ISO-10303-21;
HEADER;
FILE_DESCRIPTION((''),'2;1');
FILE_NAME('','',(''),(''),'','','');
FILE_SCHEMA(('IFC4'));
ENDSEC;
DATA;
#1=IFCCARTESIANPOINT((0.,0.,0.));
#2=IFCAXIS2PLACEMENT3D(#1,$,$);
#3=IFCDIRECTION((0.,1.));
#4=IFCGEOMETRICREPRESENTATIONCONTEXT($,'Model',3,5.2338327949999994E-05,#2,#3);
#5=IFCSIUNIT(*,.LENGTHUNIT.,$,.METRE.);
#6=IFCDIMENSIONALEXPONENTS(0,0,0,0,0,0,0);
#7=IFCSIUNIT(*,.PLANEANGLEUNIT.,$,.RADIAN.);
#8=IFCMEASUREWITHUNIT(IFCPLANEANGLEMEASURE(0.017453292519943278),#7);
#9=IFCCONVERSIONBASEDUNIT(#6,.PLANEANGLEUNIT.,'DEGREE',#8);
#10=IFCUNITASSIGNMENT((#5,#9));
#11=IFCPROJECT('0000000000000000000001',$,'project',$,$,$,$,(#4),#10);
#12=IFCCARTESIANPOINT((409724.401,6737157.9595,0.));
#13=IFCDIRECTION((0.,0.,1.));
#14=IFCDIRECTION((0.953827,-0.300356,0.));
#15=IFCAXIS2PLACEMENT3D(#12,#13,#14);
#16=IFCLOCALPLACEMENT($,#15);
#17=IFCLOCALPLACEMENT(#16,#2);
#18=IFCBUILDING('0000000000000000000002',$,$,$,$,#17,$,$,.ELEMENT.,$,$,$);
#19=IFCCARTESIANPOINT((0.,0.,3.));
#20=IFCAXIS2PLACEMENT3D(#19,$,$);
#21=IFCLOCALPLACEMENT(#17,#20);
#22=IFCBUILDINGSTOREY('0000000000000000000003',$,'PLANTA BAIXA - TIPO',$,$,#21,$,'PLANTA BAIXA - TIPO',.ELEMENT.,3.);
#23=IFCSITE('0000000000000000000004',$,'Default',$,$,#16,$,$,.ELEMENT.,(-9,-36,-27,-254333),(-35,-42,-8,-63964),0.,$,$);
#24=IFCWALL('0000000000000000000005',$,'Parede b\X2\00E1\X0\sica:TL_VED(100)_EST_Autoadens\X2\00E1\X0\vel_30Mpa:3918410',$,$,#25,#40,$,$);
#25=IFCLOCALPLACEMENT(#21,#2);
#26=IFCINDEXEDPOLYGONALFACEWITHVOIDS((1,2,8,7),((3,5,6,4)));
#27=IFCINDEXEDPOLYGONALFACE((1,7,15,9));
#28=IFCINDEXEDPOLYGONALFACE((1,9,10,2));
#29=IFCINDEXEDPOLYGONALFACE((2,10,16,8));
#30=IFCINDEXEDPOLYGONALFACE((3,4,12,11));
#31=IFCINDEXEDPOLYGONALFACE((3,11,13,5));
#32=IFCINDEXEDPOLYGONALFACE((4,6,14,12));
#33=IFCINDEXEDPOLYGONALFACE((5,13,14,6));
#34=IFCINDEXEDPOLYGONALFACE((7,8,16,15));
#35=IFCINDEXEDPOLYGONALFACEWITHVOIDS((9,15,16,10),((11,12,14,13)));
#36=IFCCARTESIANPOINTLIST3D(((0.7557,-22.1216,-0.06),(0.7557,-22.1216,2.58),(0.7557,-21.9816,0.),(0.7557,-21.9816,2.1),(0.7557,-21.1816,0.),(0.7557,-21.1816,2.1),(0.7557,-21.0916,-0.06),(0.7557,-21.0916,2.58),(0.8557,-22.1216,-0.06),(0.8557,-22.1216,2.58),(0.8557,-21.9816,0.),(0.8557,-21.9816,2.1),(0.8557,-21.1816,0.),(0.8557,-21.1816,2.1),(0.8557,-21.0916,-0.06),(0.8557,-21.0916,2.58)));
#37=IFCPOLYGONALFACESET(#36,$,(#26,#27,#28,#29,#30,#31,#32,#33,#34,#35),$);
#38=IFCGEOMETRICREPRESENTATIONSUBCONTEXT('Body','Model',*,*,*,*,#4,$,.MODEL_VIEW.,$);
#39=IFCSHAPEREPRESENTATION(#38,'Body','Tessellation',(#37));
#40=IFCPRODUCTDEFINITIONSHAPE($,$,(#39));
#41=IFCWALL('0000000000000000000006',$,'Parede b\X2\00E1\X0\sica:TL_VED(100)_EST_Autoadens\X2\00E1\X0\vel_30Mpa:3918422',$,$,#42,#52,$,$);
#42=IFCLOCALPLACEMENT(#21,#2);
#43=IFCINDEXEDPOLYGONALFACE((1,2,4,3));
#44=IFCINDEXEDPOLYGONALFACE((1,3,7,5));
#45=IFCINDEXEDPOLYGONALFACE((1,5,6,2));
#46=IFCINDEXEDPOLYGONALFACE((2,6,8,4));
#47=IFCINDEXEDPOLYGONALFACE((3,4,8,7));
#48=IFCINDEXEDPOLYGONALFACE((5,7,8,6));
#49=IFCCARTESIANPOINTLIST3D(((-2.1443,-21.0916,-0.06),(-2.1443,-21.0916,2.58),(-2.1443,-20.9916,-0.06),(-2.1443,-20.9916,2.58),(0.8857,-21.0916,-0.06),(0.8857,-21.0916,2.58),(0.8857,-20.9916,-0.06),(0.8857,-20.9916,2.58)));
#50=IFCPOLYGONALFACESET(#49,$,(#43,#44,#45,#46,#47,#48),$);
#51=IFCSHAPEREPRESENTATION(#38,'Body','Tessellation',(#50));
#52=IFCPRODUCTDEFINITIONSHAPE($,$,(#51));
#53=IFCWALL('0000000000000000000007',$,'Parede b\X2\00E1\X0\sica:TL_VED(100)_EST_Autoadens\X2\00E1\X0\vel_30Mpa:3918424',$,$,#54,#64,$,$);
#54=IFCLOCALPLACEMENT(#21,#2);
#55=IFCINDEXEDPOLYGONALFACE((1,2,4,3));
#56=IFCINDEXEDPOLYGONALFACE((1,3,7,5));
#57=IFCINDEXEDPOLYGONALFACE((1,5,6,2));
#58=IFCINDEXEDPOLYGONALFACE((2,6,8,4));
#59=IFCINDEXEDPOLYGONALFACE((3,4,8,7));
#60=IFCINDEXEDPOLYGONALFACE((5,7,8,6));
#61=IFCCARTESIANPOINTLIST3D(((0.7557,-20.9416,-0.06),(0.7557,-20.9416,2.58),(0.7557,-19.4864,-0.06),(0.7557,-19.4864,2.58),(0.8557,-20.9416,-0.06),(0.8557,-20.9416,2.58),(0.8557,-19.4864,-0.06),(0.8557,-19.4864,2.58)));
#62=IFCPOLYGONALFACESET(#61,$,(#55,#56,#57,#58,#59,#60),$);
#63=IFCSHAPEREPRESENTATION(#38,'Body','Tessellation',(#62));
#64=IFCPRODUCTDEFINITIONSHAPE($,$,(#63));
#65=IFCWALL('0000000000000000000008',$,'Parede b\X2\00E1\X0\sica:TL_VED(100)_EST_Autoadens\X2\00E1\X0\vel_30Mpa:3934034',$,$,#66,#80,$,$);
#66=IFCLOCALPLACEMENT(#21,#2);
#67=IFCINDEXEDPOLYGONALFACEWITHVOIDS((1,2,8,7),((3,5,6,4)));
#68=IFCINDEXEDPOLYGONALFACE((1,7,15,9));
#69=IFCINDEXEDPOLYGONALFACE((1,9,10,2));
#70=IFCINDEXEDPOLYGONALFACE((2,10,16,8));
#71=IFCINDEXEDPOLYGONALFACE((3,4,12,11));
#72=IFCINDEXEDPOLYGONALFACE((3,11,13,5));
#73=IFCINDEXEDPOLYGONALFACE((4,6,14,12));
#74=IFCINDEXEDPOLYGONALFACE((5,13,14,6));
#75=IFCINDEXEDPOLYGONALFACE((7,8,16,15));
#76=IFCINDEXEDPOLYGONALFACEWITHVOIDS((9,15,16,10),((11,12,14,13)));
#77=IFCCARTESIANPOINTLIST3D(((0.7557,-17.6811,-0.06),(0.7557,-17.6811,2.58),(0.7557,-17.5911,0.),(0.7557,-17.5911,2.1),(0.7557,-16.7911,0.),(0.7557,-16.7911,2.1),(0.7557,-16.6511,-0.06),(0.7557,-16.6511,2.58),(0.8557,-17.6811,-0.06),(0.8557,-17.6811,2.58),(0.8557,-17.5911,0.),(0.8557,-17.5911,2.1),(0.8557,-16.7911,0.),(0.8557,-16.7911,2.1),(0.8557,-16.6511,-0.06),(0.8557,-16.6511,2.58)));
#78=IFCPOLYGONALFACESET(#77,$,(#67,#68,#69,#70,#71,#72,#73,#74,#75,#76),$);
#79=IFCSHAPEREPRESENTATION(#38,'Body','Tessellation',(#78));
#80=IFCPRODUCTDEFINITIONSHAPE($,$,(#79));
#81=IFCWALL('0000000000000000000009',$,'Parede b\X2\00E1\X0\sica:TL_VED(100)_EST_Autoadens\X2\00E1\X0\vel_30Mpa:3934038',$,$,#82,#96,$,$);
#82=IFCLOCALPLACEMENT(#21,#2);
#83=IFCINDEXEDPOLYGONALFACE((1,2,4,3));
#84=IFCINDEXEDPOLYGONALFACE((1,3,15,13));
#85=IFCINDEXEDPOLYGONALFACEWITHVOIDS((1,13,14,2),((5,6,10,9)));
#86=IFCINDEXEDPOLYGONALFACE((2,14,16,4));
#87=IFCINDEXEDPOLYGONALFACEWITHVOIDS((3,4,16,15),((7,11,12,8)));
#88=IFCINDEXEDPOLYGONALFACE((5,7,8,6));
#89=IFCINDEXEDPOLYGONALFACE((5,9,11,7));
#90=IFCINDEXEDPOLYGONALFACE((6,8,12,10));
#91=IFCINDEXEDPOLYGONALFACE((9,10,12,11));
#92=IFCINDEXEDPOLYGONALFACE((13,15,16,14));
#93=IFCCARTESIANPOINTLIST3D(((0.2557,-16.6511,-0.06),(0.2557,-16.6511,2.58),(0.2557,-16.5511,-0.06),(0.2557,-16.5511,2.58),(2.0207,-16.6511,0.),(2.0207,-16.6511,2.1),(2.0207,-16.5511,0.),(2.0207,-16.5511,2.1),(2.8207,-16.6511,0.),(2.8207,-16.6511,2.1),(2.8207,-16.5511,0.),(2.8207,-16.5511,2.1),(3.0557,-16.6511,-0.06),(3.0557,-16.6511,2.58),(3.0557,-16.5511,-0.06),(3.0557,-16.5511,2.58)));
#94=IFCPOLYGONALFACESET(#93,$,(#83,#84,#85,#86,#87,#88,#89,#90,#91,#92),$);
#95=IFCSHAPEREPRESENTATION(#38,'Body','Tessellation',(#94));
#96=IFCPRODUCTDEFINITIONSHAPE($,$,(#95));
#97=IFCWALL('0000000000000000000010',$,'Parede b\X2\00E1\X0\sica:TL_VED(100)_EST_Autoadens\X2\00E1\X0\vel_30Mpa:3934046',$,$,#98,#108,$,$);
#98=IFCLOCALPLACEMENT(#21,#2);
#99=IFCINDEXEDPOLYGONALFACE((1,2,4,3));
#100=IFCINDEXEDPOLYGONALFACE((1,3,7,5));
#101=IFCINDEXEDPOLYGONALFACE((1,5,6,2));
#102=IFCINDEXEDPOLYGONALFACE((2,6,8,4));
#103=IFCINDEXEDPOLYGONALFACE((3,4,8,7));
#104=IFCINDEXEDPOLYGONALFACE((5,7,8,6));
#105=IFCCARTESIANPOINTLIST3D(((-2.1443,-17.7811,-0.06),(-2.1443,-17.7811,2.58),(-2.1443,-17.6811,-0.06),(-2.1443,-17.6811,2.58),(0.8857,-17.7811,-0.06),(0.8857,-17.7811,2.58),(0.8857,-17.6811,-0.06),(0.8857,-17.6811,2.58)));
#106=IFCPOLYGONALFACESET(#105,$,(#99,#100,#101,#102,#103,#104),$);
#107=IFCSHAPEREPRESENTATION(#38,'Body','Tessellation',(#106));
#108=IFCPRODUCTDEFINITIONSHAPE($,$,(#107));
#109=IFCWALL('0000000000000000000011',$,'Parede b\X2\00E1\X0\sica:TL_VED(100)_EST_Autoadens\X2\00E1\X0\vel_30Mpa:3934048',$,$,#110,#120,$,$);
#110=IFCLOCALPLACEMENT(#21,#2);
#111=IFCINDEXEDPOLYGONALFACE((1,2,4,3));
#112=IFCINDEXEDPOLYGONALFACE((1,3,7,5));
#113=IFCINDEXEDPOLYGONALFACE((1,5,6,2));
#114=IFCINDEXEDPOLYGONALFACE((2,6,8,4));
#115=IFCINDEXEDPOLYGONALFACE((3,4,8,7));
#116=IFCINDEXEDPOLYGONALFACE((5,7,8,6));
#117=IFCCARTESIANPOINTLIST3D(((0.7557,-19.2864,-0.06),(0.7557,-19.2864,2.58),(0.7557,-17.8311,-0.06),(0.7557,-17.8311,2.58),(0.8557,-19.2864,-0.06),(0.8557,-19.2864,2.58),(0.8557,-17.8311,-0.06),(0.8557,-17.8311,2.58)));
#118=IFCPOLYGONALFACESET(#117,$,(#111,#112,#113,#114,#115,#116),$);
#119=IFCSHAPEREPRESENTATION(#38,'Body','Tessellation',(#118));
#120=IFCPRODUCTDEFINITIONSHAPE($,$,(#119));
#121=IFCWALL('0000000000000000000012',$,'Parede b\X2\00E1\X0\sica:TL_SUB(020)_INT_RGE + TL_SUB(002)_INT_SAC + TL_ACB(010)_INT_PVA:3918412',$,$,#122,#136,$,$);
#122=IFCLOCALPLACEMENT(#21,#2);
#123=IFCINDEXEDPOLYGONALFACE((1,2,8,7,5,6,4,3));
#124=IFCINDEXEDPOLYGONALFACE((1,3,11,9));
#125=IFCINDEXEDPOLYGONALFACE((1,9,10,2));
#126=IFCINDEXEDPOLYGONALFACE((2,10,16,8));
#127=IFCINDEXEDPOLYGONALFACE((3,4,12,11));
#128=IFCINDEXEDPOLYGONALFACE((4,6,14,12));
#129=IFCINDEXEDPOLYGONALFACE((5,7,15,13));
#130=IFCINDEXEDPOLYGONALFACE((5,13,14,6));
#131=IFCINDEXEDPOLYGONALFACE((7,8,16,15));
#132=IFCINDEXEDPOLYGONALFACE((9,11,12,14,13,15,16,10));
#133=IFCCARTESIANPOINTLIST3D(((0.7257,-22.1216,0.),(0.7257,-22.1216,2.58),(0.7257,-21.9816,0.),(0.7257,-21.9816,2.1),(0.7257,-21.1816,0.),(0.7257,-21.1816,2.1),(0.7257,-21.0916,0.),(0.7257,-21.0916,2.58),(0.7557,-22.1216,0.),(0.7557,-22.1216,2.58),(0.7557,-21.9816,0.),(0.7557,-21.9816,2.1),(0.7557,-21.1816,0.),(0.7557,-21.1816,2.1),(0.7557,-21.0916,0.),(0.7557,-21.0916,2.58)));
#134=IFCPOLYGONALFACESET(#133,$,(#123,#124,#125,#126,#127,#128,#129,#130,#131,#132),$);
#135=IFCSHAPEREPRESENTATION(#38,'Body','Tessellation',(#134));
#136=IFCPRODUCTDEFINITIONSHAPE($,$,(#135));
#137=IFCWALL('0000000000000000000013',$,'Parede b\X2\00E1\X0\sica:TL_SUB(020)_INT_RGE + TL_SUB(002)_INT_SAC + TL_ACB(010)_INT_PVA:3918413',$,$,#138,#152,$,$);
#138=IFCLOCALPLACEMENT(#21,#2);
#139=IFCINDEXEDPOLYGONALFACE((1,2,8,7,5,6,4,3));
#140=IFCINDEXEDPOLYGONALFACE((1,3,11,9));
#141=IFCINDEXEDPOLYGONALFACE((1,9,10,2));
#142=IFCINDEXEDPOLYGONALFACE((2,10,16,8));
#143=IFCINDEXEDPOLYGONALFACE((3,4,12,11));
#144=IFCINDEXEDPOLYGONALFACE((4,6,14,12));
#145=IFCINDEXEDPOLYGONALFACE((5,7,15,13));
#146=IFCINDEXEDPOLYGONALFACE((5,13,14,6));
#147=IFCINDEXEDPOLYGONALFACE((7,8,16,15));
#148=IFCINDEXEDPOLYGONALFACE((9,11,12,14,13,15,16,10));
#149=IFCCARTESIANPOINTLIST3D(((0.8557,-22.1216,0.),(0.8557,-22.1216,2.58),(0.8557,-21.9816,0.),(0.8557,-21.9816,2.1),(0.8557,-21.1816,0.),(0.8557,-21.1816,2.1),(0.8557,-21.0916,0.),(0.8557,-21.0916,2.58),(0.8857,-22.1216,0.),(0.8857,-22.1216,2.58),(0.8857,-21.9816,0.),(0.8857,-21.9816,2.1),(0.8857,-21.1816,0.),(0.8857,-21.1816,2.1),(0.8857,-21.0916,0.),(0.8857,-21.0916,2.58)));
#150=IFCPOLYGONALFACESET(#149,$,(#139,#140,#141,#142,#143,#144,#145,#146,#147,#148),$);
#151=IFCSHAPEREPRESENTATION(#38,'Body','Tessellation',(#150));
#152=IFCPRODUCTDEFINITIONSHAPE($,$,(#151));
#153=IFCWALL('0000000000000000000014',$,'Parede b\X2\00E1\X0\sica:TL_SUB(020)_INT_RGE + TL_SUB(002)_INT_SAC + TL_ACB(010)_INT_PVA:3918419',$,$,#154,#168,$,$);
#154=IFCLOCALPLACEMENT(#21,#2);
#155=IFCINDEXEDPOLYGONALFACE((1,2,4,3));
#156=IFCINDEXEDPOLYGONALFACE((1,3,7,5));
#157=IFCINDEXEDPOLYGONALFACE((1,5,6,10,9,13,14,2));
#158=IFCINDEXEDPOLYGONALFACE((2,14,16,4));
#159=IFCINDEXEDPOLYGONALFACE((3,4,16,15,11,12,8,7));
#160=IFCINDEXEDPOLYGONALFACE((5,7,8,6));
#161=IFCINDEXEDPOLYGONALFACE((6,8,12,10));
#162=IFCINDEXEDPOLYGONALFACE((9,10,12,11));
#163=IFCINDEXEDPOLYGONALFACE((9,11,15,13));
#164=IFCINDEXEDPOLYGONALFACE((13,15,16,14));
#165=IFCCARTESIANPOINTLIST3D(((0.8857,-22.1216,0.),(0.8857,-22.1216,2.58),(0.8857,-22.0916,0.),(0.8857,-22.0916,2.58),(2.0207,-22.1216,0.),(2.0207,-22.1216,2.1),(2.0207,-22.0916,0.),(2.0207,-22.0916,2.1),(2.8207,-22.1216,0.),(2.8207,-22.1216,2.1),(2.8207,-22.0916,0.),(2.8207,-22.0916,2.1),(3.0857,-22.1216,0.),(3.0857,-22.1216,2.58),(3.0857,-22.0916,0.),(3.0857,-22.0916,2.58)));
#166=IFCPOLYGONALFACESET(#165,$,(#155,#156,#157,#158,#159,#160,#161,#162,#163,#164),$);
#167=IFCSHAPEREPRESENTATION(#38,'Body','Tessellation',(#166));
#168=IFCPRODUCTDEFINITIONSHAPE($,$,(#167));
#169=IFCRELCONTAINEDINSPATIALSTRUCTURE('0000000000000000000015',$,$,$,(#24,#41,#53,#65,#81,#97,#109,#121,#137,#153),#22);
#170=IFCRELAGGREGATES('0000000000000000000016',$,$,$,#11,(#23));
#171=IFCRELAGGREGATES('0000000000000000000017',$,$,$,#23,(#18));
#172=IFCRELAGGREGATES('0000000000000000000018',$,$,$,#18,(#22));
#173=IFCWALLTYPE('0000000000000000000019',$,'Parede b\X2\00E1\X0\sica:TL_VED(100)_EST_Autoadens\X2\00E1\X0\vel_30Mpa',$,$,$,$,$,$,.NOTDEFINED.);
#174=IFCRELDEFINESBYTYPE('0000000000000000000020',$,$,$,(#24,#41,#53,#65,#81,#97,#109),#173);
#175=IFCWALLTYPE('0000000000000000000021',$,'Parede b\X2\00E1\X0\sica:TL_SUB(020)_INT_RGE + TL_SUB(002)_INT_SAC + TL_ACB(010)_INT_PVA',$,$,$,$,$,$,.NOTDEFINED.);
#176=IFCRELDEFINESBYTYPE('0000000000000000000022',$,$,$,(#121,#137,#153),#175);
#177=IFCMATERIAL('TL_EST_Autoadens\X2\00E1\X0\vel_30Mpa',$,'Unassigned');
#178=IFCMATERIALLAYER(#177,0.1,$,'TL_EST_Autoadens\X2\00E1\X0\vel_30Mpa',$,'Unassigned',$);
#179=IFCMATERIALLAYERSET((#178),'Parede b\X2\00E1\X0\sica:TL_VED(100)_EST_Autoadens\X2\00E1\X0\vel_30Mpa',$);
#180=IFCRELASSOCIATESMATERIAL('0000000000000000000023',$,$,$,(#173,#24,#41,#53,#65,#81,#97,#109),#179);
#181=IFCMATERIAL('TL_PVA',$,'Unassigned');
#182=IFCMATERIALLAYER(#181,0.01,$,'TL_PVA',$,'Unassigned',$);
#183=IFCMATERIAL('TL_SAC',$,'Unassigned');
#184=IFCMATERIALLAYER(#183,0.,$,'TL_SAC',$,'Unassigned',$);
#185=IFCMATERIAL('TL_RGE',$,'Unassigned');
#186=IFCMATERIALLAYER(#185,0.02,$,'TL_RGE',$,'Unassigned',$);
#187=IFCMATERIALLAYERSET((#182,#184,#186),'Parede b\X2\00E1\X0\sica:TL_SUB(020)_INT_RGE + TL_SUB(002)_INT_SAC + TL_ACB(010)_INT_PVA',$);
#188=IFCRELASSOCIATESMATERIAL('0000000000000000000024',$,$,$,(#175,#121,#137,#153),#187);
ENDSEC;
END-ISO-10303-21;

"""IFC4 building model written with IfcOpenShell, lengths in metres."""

from ifc_helpers import new_model, entity, si_unit, converted_unit, direction, frame, frame_2d, origin, place, context, subcontext, project, spatial, rectangle, extrude, material, layer, layer_set, layer_usage, type_object, element, save


model = new_model("IFC4")

# Units and contexts
model_context = context("Model", 3, precision=5.2338327949999994e-05, world=origin(), true_north=direction((0.0, 1.0)))
body_context = subcontext(model_context, "Body", "Model", "MODEL_VIEW")
ifc_project = project(units=[si_unit("LENGTHUNIT", "METRE"), converted_unit("PLANEANGLEUNIT", "DEGREE", entity("IfcPlaneAngleMeasure", 0.017453292519943278), si_unit("PLANEANGLEUNIT", "RADIAN"), dimensions=[0, 0, 0, 0, 0, 0, 0])], contexts=[model_context])

# Site, building, storey
site_placement = place(None, frame((409724.401, 6737157.9595, 0.0), z_axis=(0.0, 0.0, 1.0), x_axis=(0.953827, -0.300356, 0.0)))
site = spatial("IfcSite", under=ifc_project, at=site_placement, Name="Default", CompositionType="ELEMENT", RefLatitude=(-9, -36, -27, -254333), RefLongitude=(-35, -42, -8, -63964), RefElevation=0.0)
building_placement = place(site_placement, origin())
building = spatial("IfcBuilding", under=site, at=building_placement, CompositionType="ELEMENT")
storey_placement = place(building_placement, frame((0.0, 0.0, 3.0)))
storey = spatial("IfcBuildingStorey", under=building, at=storey_placement, Name="PLANTA BAIXA - TIPO", LongName="PLANTA BAIXA - TIPO", CompositionType="ELEMENT", Elevation=3.0)

# Wall, opening
ifc_material_1 = material(Name="TL_EST_Autoadensável_30Mpa", Category="Unassigned")
ifc_layer_1 = layer(ifc_material_1, 0.1, Name="TL_EST_Autoadensável_30Mpa", Category="Unassigned")
ifc_layer_set_1 = layer_set([ifc_layer_1], Name="Parede básica:TL_VED(100)_EST_Autoadensável_30Mpa")
ifc_layer_usage_1 = layer_usage(ifc_layer_set_1, "AXIS2", "NEGATIVE", 0.05)
wall_type_1 = type_object("IfcWallType", Name="Parede básica:TL_VED(100)_EST_Autoadensável_30Mpa", PredefinedType="NOTDEFINED", material=ifc_layer_set_1)
wall_1_placement = place(storey_placement, frame((0.8057, -22.1216, -0.06), z_axis=(0.0, 0.0, 1.0), x_axis=(0.0, 1.0, 0.0)))
wall_1 = element("IfcWall", 1, at=wall_1_placement, inside=storey, type_object=wall_type_1, material=ifc_layer_usage_1, Name="Parede básica:TL_VED(100)_EST_Autoadensável_30Mpa:3918410", context=body_context, shape_type="SweptSolid", body=[
    extrude(rectangle(XDim=1.03, YDim=0.1, at=frame_2d((0.515, 0.0), x_axis=(-1.0, 0.0))), origin(), (0.0, 0.0, 1.0), 2.64),
])
opening_1_placement = place(wall_1_placement, frame((0.14, -0.05, 0.06)))
element("IfcOpeningElement", 2, at=opening_1_placement, cuts=wall_1, PredefinedType="OPENING", context=body_context, shape_type="SweptSolid", body=[
    extrude(rectangle(XDim=2.1, YDim=0.8, at=frame_2d((1.05, 0.4), x_axis=(1.0, 0.0))), frame((0.0, 0.0, 0.0), z_axis=(0.0, 1.0, 0.0), x_axis=(0.0, 0.0, 1.0)), (0.0, 0.0, 1.0), 0.1),
])

# Walls
ifc_layer_usage_2 = layer_usage(ifc_layer_set_1, "AXIS2", "POSITIVE", -0.05)
wall_2_placement = place(storey_placement, frame((0.8857, -21.0416, -0.06), z_axis=(0.0, 0.0, 1.0), x_axis=(-1.0, 0.0, 0.0)))
element("IfcWall", 3, at=wall_2_placement, inside=storey, type_object=wall_type_1, material=ifc_layer_usage_2, Name="Parede básica:TL_VED(100)_EST_Autoadensável_30Mpa:3918422", context=body_context, shape_type="SweptSolid", body=[
    extrude(rectangle(XDim=3.03, YDim=0.1, at=frame_2d((1.515, 0.0), x_axis=(-1.0, 0.0))), origin(), (0.0, 0.0, 1.0), 2.64),
])
ifc_layer_usage_3 = layer_usage(ifc_layer_set_1, "AXIS2", "NEGATIVE", 0.05)
wall_3_placement = place(storey_placement, frame((0.8057, -19.4864, -0.06), z_axis=(0.0, 0.0, 1.0), x_axis=(0.0, -1.0, 0.0)))
element("IfcWall", 4, at=wall_3_placement, inside=storey, type_object=wall_type_1, material=ifc_layer_usage_3, Name="Parede básica:TL_VED(100)_EST_Autoadensável_30Mpa:3918424", context=body_context, shape_type="SweptSolid", body=[
    extrude(rectangle(XDim=1.4552, YDim=0.1, at=frame_2d((0.7276, 0.0), x_axis=(-1.0, 0.0))), origin(), (0.0, 0.0, 1.0), 2.64),
])

# Walls, openings
ifc_layer_usage_4 = layer_usage(ifc_layer_set_1, "AXIS2", "POSITIVE", -0.05)
wall_4_placement = place(storey_placement, frame((0.8057, -16.6511, -0.06), z_axis=(0.0, 0.0, 1.0), x_axis=(0.0, -1.0, 0.0)))
wall_4 = element("IfcWall", 5, at=wall_4_placement, inside=storey, type_object=wall_type_1, material=ifc_layer_usage_4, Name="Parede básica:TL_VED(100)_EST_Autoadensável_30Mpa:3934034", context=body_context, shape_type="SweptSolid", body=[
    extrude(rectangle(XDim=1.03, YDim=0.1, at=frame_2d((0.515, 0.0), x_axis=(-1.0, 0.0))), origin(), (0.0, 0.0, 1.0), 2.64),
])
opening_2_placement = place(wall_4_placement, frame((0.94, 0.05, 0.06)))
element("IfcOpeningElement", 6, at=opening_2_placement, cuts=wall_4, PredefinedType="OPENING", context=body_context, shape_type="SweptSolid", body=[
    extrude(rectangle(XDim=2.1, YDim=0.8, at=frame_2d((1.05, 0.4), x_axis=(1.0, 0.0))), frame((0.0, 0.0, 0.0), z_axis=(0.0, -1.0, 0.0), x_axis=(0.0, 0.0, 1.0)), (0.0, 0.0, 1.0), 0.1),
])
ifc_layer_usage_5 = layer_usage(ifc_layer_set_1, "AXIS2", "POSITIVE", -0.05)
wall_5_placement = place(storey_placement, frame((3.0557, -16.6011, -0.06), z_axis=(0.0, 0.0, 1.0), x_axis=(-1.0, 0.0, 0.0)))
wall_5 = element("IfcWall", 7, at=wall_5_placement, inside=storey, type_object=wall_type_1, material=ifc_layer_usage_5, Name="Parede básica:TL_VED(100)_EST_Autoadensável_30Mpa:3934038", context=body_context, shape_type="SweptSolid", body=[
    extrude(rectangle(XDim=2.8, YDim=0.1, at=frame_2d((1.4, 0.0), x_axis=(-1.0, 0.0))), origin(), (0.0, 0.0, 1.0), 2.64),
])
opening_3_placement = place(wall_5_placement, frame((1.035, 0.05, 0.06)))
element("IfcOpeningElement", 8, at=opening_3_placement, cuts=wall_5, PredefinedType="OPENING", context=body_context, shape_type="SweptSolid", body=[
    extrude(rectangle(XDim=2.1, YDim=0.8, at=frame_2d((1.05, 0.4), x_axis=(1.0, 0.0))), frame((0.0, 0.0, 0.0), z_axis=(0.0, -1.0, 0.0), x_axis=(0.0, 0.0, 1.0)), (0.0, 0.0, 1.0), 0.1),
])

# Walls
ifc_layer_usage_6 = layer_usage(ifc_layer_set_1, "AXIS2", "NEGATIVE", 0.05)
wall_6_placement = place(storey_placement, frame((0.8857, -17.7311, -0.06), z_axis=(0.0, 0.0, 1.0), x_axis=(-1.0, 0.0, 0.0)))
element("IfcWall", 9, at=wall_6_placement, inside=storey, type_object=wall_type_1, material=ifc_layer_usage_6, Name="Parede básica:TL_VED(100)_EST_Autoadensável_30Mpa:3934046", context=body_context, shape_type="SweptSolid", body=[
    extrude(rectangle(XDim=3.03, YDim=0.1, at=frame_2d((1.515, 0.0), x_axis=(-1.0, 0.0))), origin(), (0.0, 0.0, 1.0), 2.64),
])
ifc_layer_usage_7 = layer_usage(ifc_layer_set_1, "AXIS2", "POSITIVE", -0.05)
wall_7_placement = place(storey_placement, frame((0.8057, -19.2864, -0.06), z_axis=(0.0, 0.0, 1.0), x_axis=(0.0, 1.0, 0.0)))
element("IfcWall", 10, at=wall_7_placement, inside=storey, type_object=wall_type_1, material=ifc_layer_usage_7, Name="Parede básica:TL_VED(100)_EST_Autoadensável_30Mpa:3934048", context=body_context, shape_type="SweptSolid", body=[
    extrude(rectangle(XDim=1.4552, YDim=0.1, at=frame_2d((0.7276, 0.0), x_axis=(-1.0, 0.0))), origin(), (0.0, 0.0, 1.0), 2.64),
])

# Walls, openings
ifc_material_2 = material(Name="TL_PVA", Category="Unassigned")
ifc_layer_2 = layer(ifc_material_2, 0.01, Name="TL_PVA", Category="Unassigned")
ifc_material_3 = material(Name="TL_SAC", Category="Unassigned")
ifc_layer_3 = layer(ifc_material_3, 0.0, Name="TL_SAC", Category="Unassigned")
ifc_material_4 = material(Name="TL_RGE", Category="Unassigned")
ifc_layer_4 = layer(ifc_material_4, 0.02, Name="TL_RGE", Category="Unassigned")
ifc_layer_set_2 = layer_set([ifc_layer_2, ifc_layer_3, ifc_layer_4], Name="Parede básica:TL_SUB(020)_INT_RGE + TL_SUB(002)_INT_SAC + TL_ACB(010)_INT_PVA")
ifc_layer_usage_8 = layer_usage(ifc_layer_set_2, "AXIS2", "NEGATIVE", 0.015)
wall_type_2 = type_object("IfcWallType", Name="Parede básica:TL_SUB(020)_INT_RGE + TL_SUB(002)_INT_SAC + TL_ACB(010)_INT_PVA", PredefinedType="NOTDEFINED", material=ifc_layer_set_2)
wall_8_placement = place(storey_placement, frame((0.7407, -22.1216, 0.0), z_axis=(0.0, 0.0, 1.0), x_axis=(0.0, 1.0, 0.0)))
wall_8 = element("IfcWall", 11, at=wall_8_placement, inside=storey, type_object=wall_type_2, material=ifc_layer_usage_8, Name="Parede básica:TL_SUB(020)_INT_RGE + TL_SUB(002)_INT_SAC + TL_ACB(010)_INT_PVA:3918412", context=body_context, shape_type="SweptSolid", body=[
    extrude(rectangle(XDim=1.03, YDim=0.03, at=frame_2d((0.515, 0.0), x_axis=(1.0, 0.0))), origin(), (0.0, 0.0, 1.0), 2.58),
])
opening_4_placement = place(wall_8_placement, frame((22.1216, 0.7407, 0.0)))
element("IfcOpeningElement", 12, at=opening_4_placement, cuts=wall_8, PredefinedType="OPENING", context=body_context, shape_type="SweptSolid", body=[
    extrude(rectangle(XDim=2.1, YDim=0.8, at=frame_2d((0.0, 0.0), x_axis=(0.0, 1.0))), frame((-21.5816, -2.3797, 1.05), z_axis=(0.0, 1.0, 0.0), x_axis=(-1.0, 0.0, 0.0)), (0.0, 0.0, 1.0), 3.048),
])
ifc_layer_usage_9 = layer_usage(ifc_layer_set_2, "AXIS2", "NEGATIVE", 0.015)
wall_9_placement = place(storey_placement, frame((0.8707, -21.0916, 0.0), z_axis=(0.0, 0.0, 1.0), x_axis=(0.0, -1.0, 0.0)))
wall_9 = element("IfcWall", 13, at=wall_9_placement, inside=storey, type_object=wall_type_2, material=ifc_layer_usage_9, Name="Parede básica:TL_SUB(020)_INT_RGE + TL_SUB(002)_INT_SAC + TL_ACB(010)_INT_PVA:3918413", context=body_context, shape_type="SweptSolid", body=[
    extrude(rectangle(XDim=1.03, YDim=0.03, at=frame_2d((0.515, 0.0), x_axis=(1.0, 0.0))), origin(), (0.0, 0.0, 1.0), 2.58),
])
opening_5_placement = place(wall_9_placement, frame((-21.0916, -0.8707, 0.0)))
element("IfcOpeningElement", 14, at=opening_5_placement, cuts=wall_9, PredefinedType="OPENING", context=body_context, shape_type="SweptSolid", body=[
    extrude(rectangle(XDim=2.1, YDim=0.8, at=frame_2d((0.0, 0.0), x_axis=(1.0, 0.0))), frame((21.5816, -0.6683, 1.05), z_axis=(0.0, 1.0, 0.0), x_axis=(0.0, 0.0, 1.0)), (0.0, 0.0, 1.0), 3.048),
])
ifc_layer_usage_10 = layer_usage(ifc_layer_set_2, "AXIS2", "NEGATIVE", 0.015)
wall_10_placement = place(storey_placement, frame((0.8857, -22.1066, 0.0)))
wall_10 = element("IfcWall", 15, at=wall_10_placement, inside=storey, type_object=wall_type_2, material=ifc_layer_usage_10, Name="Parede básica:TL_SUB(020)_INT_RGE + TL_SUB(002)_INT_SAC + TL_ACB(010)_INT_PVA:3918419", context=body_context, shape_type="SweptSolid", body=[
    extrude(rectangle(XDim=2.2, YDim=0.03, at=frame_2d((1.1, 0.0), x_axis=(1.0, 0.0))), origin(), (0.0, 0.0, 1.0), 2.58),
])
opening_6_placement = place(wall_10_placement, frame((-0.8857, 22.1066, 0.0)))
element("IfcOpeningElement", 16, at=opening_6_placement, cuts=wall_10, PredefinedType="OPENING", context=body_context, shape_type="SweptSolid", body=[
    extrude(rectangle(XDim=2.1, YDim=0.8, at=frame_2d((0.0, 0.0), x_axis=(0.0, 1.0))), frame((2.4207, -23.6456, 1.05), z_axis=(0.0, 1.0, 0.0), x_axis=(-1.0, 0.0, 0.0)), (0.0, 0.0, 1.0), 3.048),
])

save(model, "model.ifc")
